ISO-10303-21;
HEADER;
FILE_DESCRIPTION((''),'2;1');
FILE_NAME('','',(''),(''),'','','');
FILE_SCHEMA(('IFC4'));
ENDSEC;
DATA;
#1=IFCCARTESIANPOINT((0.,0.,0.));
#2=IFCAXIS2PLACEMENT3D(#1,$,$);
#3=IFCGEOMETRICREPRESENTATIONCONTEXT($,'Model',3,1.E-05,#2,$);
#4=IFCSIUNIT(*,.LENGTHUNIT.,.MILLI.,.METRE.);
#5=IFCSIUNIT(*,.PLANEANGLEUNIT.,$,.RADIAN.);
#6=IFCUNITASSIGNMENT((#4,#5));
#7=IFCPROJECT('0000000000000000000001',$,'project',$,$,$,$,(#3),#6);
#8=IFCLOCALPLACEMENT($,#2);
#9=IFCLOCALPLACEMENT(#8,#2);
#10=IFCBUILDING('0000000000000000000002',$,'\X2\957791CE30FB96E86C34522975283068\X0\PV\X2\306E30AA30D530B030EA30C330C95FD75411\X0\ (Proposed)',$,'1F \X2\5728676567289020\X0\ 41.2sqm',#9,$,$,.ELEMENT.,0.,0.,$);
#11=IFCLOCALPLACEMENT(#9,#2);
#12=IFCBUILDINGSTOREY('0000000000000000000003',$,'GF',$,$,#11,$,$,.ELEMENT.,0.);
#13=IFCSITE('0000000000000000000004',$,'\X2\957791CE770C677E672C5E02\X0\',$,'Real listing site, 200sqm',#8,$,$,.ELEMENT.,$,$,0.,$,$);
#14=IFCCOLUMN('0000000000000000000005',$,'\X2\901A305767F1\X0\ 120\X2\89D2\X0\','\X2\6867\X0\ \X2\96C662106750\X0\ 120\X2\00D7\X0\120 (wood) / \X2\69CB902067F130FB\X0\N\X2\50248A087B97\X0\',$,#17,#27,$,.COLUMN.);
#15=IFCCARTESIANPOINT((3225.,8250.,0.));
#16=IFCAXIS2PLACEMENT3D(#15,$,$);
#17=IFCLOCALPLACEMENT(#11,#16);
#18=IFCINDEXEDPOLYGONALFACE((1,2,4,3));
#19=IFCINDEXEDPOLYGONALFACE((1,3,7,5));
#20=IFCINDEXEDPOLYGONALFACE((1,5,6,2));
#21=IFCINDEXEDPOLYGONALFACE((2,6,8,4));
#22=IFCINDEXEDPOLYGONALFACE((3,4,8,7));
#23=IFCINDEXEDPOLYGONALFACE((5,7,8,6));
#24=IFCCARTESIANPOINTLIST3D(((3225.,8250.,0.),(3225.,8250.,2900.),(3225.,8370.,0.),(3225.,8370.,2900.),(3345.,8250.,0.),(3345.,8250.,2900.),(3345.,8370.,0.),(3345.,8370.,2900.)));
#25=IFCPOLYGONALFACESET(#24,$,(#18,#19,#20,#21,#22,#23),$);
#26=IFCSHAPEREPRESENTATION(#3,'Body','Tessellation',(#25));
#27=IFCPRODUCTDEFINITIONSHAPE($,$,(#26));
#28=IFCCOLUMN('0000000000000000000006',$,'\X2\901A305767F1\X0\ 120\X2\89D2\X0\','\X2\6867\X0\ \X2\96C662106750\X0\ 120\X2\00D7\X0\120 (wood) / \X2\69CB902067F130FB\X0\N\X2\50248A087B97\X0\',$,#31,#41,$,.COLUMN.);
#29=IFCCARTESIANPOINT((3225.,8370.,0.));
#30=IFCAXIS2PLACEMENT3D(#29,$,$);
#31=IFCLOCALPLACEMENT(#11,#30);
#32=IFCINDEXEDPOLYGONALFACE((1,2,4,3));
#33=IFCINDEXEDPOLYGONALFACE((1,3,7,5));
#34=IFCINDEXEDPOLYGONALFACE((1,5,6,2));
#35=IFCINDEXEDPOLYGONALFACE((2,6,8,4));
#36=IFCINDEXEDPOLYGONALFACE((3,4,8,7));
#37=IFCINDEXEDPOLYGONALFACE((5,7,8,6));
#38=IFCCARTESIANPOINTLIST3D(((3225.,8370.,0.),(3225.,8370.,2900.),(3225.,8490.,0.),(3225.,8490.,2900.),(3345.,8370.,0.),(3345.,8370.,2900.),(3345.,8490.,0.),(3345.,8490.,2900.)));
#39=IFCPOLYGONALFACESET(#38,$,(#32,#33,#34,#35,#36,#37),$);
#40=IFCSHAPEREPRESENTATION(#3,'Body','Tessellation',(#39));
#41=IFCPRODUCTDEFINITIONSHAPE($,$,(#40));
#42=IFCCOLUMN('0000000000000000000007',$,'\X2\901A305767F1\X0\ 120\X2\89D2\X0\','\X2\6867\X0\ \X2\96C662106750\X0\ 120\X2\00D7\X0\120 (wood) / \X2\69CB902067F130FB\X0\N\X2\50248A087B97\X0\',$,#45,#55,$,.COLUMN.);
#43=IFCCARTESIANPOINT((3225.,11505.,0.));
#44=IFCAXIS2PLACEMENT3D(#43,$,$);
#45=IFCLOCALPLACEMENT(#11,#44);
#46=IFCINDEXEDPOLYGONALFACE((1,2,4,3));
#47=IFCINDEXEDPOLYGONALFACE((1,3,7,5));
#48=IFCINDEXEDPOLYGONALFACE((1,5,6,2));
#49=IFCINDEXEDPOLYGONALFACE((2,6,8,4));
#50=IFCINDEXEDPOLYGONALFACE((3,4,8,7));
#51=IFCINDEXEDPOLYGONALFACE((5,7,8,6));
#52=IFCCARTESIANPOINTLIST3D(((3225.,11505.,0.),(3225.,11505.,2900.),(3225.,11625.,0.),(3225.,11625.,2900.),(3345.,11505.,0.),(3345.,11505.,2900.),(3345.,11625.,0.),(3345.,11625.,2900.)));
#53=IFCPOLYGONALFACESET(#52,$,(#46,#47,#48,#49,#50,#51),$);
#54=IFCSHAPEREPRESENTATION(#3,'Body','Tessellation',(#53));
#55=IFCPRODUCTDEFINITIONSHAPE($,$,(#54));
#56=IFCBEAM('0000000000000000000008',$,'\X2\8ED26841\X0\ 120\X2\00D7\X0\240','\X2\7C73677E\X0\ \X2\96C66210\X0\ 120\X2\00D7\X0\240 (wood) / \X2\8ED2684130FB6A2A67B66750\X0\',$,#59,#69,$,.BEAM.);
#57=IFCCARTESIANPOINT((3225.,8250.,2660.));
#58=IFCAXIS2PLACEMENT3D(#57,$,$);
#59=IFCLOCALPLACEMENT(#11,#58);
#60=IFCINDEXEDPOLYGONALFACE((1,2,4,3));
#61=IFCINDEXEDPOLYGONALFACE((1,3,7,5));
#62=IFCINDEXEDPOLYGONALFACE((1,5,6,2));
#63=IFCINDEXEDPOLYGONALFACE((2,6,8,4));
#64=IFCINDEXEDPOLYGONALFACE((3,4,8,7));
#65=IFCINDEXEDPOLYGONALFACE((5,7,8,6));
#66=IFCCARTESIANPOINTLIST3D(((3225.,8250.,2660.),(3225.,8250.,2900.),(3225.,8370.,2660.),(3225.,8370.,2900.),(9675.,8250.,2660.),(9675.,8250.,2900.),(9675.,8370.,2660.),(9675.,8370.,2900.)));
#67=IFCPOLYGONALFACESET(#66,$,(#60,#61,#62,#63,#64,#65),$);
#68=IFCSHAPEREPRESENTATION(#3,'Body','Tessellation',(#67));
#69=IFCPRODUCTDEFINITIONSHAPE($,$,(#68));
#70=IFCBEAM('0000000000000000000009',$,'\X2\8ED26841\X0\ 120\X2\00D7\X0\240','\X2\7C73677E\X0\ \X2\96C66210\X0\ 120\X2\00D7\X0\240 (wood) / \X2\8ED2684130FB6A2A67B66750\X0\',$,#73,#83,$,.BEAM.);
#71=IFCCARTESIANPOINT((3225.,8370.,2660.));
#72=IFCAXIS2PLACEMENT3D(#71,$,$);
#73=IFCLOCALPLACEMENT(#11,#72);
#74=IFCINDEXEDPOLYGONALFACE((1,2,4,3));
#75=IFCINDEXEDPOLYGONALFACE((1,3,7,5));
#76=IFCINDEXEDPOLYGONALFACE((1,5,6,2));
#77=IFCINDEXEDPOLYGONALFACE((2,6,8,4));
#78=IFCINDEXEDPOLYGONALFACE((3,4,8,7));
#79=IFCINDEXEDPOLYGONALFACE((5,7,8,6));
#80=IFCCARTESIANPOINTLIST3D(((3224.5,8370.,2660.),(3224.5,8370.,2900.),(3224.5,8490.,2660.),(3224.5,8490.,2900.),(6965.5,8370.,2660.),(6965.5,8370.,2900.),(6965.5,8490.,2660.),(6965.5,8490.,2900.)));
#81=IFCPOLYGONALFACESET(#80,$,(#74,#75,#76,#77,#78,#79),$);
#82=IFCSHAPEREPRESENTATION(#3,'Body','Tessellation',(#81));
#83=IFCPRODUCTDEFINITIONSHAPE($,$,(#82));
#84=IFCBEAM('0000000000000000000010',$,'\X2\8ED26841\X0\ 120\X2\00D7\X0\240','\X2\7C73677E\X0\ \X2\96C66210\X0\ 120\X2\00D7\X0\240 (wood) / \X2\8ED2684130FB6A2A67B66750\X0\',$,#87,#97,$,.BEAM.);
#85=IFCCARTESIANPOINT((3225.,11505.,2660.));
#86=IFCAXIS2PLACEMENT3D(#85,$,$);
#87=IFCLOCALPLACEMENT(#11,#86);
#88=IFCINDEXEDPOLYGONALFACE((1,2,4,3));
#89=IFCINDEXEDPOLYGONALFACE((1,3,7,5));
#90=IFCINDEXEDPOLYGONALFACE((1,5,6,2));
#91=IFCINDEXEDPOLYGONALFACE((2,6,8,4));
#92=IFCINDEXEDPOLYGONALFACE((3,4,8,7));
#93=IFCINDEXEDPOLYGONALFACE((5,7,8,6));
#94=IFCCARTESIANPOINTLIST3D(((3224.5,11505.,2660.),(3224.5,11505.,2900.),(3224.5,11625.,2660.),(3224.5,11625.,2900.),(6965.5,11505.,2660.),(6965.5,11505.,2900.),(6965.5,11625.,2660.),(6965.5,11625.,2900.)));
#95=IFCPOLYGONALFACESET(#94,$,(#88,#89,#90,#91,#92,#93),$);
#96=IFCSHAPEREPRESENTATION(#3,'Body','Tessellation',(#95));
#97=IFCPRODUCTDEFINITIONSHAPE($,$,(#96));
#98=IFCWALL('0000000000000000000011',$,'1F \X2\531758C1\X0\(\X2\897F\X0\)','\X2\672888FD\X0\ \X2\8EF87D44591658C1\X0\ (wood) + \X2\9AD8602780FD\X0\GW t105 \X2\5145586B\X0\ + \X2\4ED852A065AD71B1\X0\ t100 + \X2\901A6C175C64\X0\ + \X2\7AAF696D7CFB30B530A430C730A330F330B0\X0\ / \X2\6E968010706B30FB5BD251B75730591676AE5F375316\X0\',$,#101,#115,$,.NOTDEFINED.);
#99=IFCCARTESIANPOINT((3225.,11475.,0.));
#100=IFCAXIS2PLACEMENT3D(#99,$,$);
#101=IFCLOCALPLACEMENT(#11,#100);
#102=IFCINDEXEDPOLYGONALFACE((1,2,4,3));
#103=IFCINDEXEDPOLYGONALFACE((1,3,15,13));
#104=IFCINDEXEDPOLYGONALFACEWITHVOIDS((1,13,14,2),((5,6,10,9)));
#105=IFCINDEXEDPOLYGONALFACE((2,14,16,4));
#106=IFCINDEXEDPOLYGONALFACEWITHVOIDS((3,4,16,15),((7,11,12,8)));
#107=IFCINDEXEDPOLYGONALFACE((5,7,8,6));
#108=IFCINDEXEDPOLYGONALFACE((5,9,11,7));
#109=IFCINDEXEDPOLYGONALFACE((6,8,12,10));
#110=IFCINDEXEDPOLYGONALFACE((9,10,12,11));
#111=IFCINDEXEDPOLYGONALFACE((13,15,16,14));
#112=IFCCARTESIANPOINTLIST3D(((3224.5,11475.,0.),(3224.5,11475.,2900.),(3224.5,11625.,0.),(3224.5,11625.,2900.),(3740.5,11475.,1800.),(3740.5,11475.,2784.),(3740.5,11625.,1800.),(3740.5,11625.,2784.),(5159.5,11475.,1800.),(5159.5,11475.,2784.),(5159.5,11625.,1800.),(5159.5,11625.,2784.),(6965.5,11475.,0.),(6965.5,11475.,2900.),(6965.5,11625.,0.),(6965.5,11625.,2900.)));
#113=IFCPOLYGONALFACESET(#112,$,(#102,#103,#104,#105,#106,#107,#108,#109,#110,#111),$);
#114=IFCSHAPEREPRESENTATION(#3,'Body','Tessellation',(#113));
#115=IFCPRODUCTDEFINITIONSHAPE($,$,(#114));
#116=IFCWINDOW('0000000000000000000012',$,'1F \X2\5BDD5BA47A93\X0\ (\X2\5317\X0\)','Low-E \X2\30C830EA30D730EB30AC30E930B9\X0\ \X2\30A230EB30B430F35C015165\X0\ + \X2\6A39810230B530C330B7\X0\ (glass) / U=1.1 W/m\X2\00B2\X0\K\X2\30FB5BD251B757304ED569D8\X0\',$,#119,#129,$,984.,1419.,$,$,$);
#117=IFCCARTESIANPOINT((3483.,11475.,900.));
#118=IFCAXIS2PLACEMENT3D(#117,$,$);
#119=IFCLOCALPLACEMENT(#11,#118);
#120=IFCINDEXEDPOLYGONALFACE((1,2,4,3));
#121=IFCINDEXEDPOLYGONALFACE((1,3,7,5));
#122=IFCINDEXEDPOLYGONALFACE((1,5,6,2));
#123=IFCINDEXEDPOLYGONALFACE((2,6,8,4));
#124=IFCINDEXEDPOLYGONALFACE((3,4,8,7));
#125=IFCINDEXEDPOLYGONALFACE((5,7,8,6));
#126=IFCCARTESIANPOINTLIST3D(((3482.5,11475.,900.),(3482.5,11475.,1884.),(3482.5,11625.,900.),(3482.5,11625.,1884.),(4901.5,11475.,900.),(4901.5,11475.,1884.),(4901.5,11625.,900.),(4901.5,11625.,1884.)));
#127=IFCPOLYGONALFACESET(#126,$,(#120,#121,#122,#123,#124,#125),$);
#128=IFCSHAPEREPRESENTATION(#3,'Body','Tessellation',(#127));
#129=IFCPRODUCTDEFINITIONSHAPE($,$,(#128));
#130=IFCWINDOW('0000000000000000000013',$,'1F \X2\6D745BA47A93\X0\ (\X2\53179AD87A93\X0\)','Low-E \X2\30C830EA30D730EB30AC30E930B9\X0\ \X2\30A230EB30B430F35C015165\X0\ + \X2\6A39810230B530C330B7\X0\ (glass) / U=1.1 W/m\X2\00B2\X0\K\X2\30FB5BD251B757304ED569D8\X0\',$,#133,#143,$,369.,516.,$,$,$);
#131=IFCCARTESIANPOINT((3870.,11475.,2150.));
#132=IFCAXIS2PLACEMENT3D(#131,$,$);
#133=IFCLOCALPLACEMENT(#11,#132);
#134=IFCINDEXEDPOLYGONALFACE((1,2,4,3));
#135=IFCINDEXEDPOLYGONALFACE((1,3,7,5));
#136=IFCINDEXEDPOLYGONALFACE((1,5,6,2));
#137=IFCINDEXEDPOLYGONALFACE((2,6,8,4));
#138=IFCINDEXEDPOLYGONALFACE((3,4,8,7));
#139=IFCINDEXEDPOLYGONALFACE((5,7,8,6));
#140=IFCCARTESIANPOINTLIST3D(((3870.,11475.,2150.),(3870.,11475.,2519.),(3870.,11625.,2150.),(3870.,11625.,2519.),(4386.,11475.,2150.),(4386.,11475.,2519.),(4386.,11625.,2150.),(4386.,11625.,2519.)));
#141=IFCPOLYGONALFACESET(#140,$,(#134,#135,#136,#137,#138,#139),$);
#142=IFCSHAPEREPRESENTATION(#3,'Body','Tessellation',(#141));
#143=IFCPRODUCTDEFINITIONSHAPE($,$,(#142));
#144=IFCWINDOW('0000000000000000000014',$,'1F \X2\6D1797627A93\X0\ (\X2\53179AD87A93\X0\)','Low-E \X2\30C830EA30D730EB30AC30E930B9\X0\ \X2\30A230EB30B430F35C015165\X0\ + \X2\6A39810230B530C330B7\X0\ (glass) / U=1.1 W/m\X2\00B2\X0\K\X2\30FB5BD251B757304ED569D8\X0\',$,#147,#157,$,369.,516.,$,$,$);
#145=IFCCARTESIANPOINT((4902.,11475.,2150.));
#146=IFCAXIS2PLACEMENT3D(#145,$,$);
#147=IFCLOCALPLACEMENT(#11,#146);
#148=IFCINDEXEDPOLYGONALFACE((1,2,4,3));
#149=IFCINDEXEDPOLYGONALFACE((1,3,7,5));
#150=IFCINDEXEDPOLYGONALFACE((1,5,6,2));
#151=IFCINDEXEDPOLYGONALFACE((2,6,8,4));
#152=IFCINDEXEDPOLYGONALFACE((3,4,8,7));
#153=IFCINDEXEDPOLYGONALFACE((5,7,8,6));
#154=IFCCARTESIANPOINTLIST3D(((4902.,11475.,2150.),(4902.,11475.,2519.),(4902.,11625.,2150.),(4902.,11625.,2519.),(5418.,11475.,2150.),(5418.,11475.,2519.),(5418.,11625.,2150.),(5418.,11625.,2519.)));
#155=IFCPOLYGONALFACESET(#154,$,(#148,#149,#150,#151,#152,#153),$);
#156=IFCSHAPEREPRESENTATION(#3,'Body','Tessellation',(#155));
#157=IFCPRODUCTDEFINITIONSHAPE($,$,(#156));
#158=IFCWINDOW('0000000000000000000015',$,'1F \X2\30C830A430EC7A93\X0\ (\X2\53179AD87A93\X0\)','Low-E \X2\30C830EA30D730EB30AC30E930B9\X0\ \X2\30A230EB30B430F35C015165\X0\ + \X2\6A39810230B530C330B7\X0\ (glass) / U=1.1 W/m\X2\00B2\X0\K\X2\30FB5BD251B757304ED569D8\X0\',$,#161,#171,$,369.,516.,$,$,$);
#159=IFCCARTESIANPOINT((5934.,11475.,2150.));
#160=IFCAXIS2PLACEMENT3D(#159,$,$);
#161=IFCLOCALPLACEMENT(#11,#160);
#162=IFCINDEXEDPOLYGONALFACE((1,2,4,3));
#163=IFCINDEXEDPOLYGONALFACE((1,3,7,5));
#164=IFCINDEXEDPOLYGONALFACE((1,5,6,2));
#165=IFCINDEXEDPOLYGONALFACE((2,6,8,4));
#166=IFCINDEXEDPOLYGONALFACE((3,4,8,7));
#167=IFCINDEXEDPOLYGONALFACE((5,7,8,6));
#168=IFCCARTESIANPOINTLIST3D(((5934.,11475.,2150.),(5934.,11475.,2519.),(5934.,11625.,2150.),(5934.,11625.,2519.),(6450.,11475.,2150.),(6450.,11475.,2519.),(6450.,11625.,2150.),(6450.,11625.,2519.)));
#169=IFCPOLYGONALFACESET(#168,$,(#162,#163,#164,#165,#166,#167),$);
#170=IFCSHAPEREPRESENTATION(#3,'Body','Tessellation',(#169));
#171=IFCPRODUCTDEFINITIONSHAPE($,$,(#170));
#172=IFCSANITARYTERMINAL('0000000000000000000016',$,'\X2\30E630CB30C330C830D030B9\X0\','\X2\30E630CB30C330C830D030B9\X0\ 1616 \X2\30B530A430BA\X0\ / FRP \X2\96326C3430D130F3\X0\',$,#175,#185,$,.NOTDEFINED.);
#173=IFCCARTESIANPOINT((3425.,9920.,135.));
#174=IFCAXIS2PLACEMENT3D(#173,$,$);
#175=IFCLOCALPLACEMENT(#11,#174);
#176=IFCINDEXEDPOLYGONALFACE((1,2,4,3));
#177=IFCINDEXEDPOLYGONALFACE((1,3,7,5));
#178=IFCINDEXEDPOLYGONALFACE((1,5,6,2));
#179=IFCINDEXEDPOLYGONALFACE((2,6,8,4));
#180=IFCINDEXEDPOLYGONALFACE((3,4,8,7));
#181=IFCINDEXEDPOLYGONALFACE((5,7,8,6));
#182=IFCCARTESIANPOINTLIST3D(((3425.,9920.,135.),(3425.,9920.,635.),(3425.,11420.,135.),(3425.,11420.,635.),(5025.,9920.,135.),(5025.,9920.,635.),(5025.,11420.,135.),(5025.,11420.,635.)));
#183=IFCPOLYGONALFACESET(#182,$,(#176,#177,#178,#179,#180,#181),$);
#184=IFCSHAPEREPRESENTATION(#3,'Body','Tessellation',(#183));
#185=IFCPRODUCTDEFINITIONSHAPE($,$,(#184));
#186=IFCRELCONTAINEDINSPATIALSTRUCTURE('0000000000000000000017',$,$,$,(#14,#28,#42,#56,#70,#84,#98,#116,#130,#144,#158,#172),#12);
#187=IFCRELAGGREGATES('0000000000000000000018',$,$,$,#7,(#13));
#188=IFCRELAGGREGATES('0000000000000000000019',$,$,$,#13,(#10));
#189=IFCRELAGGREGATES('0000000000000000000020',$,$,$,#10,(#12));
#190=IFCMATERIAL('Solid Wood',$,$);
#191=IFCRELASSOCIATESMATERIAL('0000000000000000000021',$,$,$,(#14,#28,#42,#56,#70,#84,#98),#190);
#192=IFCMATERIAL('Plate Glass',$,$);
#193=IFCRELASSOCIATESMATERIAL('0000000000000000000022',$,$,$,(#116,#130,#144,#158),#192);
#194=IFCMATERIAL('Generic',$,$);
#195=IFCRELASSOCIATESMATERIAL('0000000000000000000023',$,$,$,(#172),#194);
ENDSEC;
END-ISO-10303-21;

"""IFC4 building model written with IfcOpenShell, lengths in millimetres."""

from ifc_helpers import new_model, si_unit, frame, frame_2d, origin, place, context, project, spatial, rectangle, extrude, material, element, fill, save


model = new_model("IFC4")

# Units and contexts
model_context = context("Model", 3, precision=1e-05, world=origin())
ifc_project = project(units=[si_unit("LENGTHUNIT", "METRE", prefix="MILLI"), si_unit("PLANEANGLEUNIT", "RADIAN")], contexts=[model_context])

# Site, building, storey
site_placement = place(None, origin())
site = spatial("IfcSite", under=ifc_project, at=site_placement, Name="長野県松本市", ObjectType="Real listing site, 200sqm", CompositionType="ELEMENT", RefElevation=0.0)
building_placement = place(site_placement, origin())
building = spatial("IfcBuilding", under=site, at=building_placement, Name="長野・雨水利用とPVのオフグリッド志向 (Proposed)", ObjectType="1F 在来木造 41.2sqm", CompositionType="ELEMENT", ElevationOfRefHeight=0.0, ElevationOfTerrain=0.0)
storey_placement = place(building_placement, origin())
storey = spatial("IfcBuildingStorey", under=building, at=storey_placement, Name="GF", CompositionType="ELEMENT", Elevation=0.0)

# Columns
ifc_material_1 = material(Name="Solid Wood")
column_1_placement = place(storey_placement, frame((3225.0, 8250.0, 0.0)))
element("IfcColumn", 1, at=column_1_placement, inside=storey, material=ifc_material_1, Name="通し柱 120角", Description="桧 集成材 120×120 (wood) / 構造柱・N値計算", PredefinedType="COLUMN", context=model_context, shape_type="SweptSolid", body=[
    extrude(rectangle(XDim=120.0, YDim=120.0, at=frame_2d((60.0, 60.0))), frame((3225.0, 8250.0, 0.0)), (0.0, 0.0, 1.0), 2900.0),
])
column_2_placement = place(storey_placement, frame((3225.0, 8370.0, 0.0)))
element("IfcColumn", 2, at=column_2_placement, inside=storey, material=ifc_material_1, Name="通し柱 120角", Description="桧 集成材 120×120 (wood) / 構造柱・N値計算", PredefinedType="COLUMN", context=model_context, shape_type="SweptSolid", body=[
    extrude(rectangle(XDim=120.0, YDim=120.0, at=frame_2d((60.0, 60.0))), frame((3225.0, 8370.0, 0.0)), (0.0, 0.0, 1.0), 2900.0),
])
column_3_placement = place(storey_placement, frame((3225.0, 11505.0, 0.0)))
element("IfcColumn", 3, at=column_3_placement, inside=storey, material=ifc_material_1, Name="通し柱 120角", Description="桧 集成材 120×120 (wood) / 構造柱・N値計算", PredefinedType="COLUMN", context=model_context, shape_type="SweptSolid", body=[
    extrude(rectangle(XDim=120.0, YDim=120.0, at=frame_2d((60.0, 60.0))), frame((3225.0, 11505.0, 0.0)), (0.0, 0.0, 1.0), 2900.0),
])

# Beams
beam_1_placement = place(storey_placement, frame((3225.0, 8250.0, 2660.0)))
element("IfcBeam", 4, at=beam_1_placement, inside=storey, material=ifc_material_1, Name="軒桁 120×240", Description="米松 集成 120×240 (wood) / 軒桁・横架材", PredefinedType="BEAM", context=model_context, shape_type="SweptSolid", body=[
    extrude(rectangle(XDim=6450.0, YDim=120.0, at=frame_2d((3225.0, 60.0))), frame((3225.0, 8250.0, 2660.0)), (0.0, 0.0, 1.0), 240.0),
])
beam_2_placement = place(storey_placement, frame((3225.0, 8370.0, 2660.0)))
element("IfcBeam", 5, at=beam_2_placement, inside=storey, material=ifc_material_1, Name="軒桁 120×240", Description="米松 集成 120×240 (wood) / 軒桁・横架材", PredefinedType="BEAM", context=model_context, shape_type="SweptSolid", body=[
    extrude(rectangle(XDim=3741.0, YDim=120.0, at=frame_2d((1870.0, 60.0))), frame((3225.0, 8370.0, 2660.0)), (0.0, 0.0, 1.0), 240.0),
])
beam_3_placement = place(storey_placement, frame((3225.0, 11505.0, 2660.0)))
element("IfcBeam", 6, at=beam_3_placement, inside=storey, material=ifc_material_1, Name="軒桁 120×240", Description="米松 集成 120×240 (wood) / 軒桁・横架材", PredefinedType="BEAM", context=model_context, shape_type="SweptSolid", body=[
    extrude(rectangle(XDim=3741.0, YDim=120.0, at=frame_2d((1870.0, 60.0))), frame((3225.0, 11505.0, 2660.0)), (0.0, 0.0, 1.0), 240.0),
])

# Wall, openings, windows
wall_1_placement = place(storey_placement, frame((3225.0, 11475.0, 0.0)))
wall_1 = element("IfcWall", 7, at=wall_1_placement, inside=storey, material=ifc_material_1, Name="1F 北壁(西)", Description="木製 軸組外壁 (wood) + 高性能GW t105 充填 + 付加断熱 t100 + 通気層 + 窯業系サイディング / 準耐火・寒冷地外皮強化", PredefinedType="NOTDEFINED", context=model_context, shape_type="SweptSolid", body=[
    extrude(rectangle(XDim=3741.0, YDim=150.0, at=frame_2d((1870.0, 75.0))), frame((3225.0, 11475.0, 0.0)), (0.0, 0.0, 1.0), 2900.0),
])
opening_1_placement = place(storey_placement, frame((3483.0, 11475.0, 900.0)))
opening_1 = element("IfcOpeningElement", 8, at=opening_1_placement, cuts=wall_1, PredefinedType="NOTDEFINED", context=model_context, shape_type="SweptSolid", body=[
    extrude(rectangle(XDim=1419.0, YDim=150.0, at=frame_2d((709.0, 75.0))), frame((3483.0, 11475.0, 900.0)), (0.0, 0.0, 1.0), 984.0),
])
opening_2_placement = place(storey_placement, frame((3870.0, 11475.0, 2150.0)))
opening_2 = element("IfcOpeningElement", 9, at=opening_2_placement, cuts=wall_1, PredefinedType="NOTDEFINED", context=model_context, shape_type="SweptSolid", body=[
    extrude(rectangle(XDim=516.0, YDim=150.0, at=frame_2d((258.0, 75.0))), frame((3870.0, 11475.0, 2150.0)), (0.0, 0.0, 1.0), 369.0),
])
opening_3_placement = place(storey_placement, frame((4902.0, 11475.0, 2150.0)))
opening_3 = element("IfcOpeningElement", 10, at=opening_3_placement, cuts=wall_1, PredefinedType="NOTDEFINED", context=model_context, shape_type="SweptSolid", body=[
    extrude(rectangle(XDim=516.0, YDim=150.0, at=frame_2d((258.0, 75.0))), frame((4902.0, 11475.0, 2150.0)), (0.0, 0.0, 1.0), 369.0),
])
opening_4_placement = place(storey_placement, frame((5934.0, 11475.0, 2150.0)))
opening_4 = element("IfcOpeningElement", 11, at=opening_4_placement, cuts=wall_1, PredefinedType="NOTDEFINED", context=model_context, shape_type="SweptSolid", body=[
    extrude(rectangle(XDim=516.0, YDim=150.0, at=frame_2d((258.0, 75.0))), frame((5934.0, 11475.0, 2150.0)), (0.0, 0.0, 1.0), 369.0),
])
ifc_material_2 = material(Name="Plate Glass")
window_1_placement = place(storey_placement, frame((3483.0, 11475.0, 900.0)))
window_1 = element("IfcWindow", 12, at=window_1_placement, inside=storey, material=ifc_material_2, Name="1F 寝室窓 (北)", Description="Low-E トリプルガラス アルゴン封入 + 樹脂サッシ (glass) / U=1.1 W/m²K・寒冷地仕様", OverallHeight=984.0, OverallWidth=1419.0, context=model_context, shape_type="SweptSolid", body=[
    extrude(rectangle(XDim=1419.0, YDim=150.0, at=frame_2d((709.0, 75.0))), frame((3483.0, 11475.0, 900.0)), (0.0, 0.0, 1.0), 984.0),
])
fill(opening_1, window_1)
window_2_placement = place(storey_placement, frame((3870.0, 11475.0, 2150.0)))
window_2 = element("IfcWindow", 13, at=window_2_placement, inside=storey, material=ifc_material_2, Name="1F 浴室窓 (北高窓)", Description="Low-E トリプルガラス アルゴン封入 + 樹脂サッシ (glass) / U=1.1 W/m²K・寒冷地仕様", OverallHeight=369.0, OverallWidth=516.0, context=model_context, shape_type="SweptSolid", body=[
    extrude(rectangle(XDim=516.0, YDim=150.0, at=frame_2d((258.0, 75.0))), frame((3870.0, 11475.0, 2150.0)), (0.0, 0.0, 1.0), 369.0),
])
fill(opening_2, window_2)
window_3_placement = place(storey_placement, frame((4902.0, 11475.0, 2150.0)))
window_3 = element("IfcWindow", 14, at=window_3_placement, inside=storey, material=ifc_material_2, Name="1F 洗面窓 (北高窓)", Description="Low-E トリプルガラス アルゴン封入 + 樹脂サッシ (glass) / U=1.1 W/m²K・寒冷地仕様", OverallHeight=369.0, OverallWidth=516.0, context=model_context, shape_type="SweptSolid", body=[
    extrude(rectangle(XDim=516.0, YDim=150.0, at=frame_2d((258.0, 75.0))), frame((4902.0, 11475.0, 2150.0)), (0.0, 0.0, 1.0), 369.0),
])
fill(opening_3, window_3)
window_4_placement = place(storey_placement, frame((5934.0, 11475.0, 2150.0)))
window_4 = element("IfcWindow", 15, at=window_4_placement, inside=storey, material=ifc_material_2, Name="1F トイレ窓 (北高窓)", Description="Low-E トリプルガラス アルゴン封入 + 樹脂サッシ (glass) / U=1.1 W/m²K・寒冷地仕様", OverallHeight=369.0, OverallWidth=516.0, context=model_context, shape_type="SweptSolid", body=[
    extrude(rectangle(XDim=516.0, YDim=150.0, at=frame_2d((258.0, 75.0))), frame((5934.0, 11475.0, 2150.0)), (0.0, 0.0, 1.0), 369.0),
])
fill(opening_4, window_4)

# Shared definitions
ifc_material_3 = material(Name="Generic")

# Sanitary terminal
sanitary_terminal_placement = place(storey_placement, frame((3425.0, 9920.0, 135.0)))
element("IfcSanitaryTerminal", 16, at=sanitary_terminal_placement, inside=storey, material=ifc_material_3, Name="ユニットバス", Description="ユニットバス 1616 サイズ / FRP 防水パン", PredefinedType="NOTDEFINED", context=model_context, shape_type="SweptSolid", body=[
    extrude(rectangle(XDim=1600.0, YDim=1500.0, at=frame_2d((800.0, 750.0))), frame((3425.0, 9920.0, 135.0)), (0.0, 0.0, 1.0), 500.0),
])

save(model, "model.ifc")
